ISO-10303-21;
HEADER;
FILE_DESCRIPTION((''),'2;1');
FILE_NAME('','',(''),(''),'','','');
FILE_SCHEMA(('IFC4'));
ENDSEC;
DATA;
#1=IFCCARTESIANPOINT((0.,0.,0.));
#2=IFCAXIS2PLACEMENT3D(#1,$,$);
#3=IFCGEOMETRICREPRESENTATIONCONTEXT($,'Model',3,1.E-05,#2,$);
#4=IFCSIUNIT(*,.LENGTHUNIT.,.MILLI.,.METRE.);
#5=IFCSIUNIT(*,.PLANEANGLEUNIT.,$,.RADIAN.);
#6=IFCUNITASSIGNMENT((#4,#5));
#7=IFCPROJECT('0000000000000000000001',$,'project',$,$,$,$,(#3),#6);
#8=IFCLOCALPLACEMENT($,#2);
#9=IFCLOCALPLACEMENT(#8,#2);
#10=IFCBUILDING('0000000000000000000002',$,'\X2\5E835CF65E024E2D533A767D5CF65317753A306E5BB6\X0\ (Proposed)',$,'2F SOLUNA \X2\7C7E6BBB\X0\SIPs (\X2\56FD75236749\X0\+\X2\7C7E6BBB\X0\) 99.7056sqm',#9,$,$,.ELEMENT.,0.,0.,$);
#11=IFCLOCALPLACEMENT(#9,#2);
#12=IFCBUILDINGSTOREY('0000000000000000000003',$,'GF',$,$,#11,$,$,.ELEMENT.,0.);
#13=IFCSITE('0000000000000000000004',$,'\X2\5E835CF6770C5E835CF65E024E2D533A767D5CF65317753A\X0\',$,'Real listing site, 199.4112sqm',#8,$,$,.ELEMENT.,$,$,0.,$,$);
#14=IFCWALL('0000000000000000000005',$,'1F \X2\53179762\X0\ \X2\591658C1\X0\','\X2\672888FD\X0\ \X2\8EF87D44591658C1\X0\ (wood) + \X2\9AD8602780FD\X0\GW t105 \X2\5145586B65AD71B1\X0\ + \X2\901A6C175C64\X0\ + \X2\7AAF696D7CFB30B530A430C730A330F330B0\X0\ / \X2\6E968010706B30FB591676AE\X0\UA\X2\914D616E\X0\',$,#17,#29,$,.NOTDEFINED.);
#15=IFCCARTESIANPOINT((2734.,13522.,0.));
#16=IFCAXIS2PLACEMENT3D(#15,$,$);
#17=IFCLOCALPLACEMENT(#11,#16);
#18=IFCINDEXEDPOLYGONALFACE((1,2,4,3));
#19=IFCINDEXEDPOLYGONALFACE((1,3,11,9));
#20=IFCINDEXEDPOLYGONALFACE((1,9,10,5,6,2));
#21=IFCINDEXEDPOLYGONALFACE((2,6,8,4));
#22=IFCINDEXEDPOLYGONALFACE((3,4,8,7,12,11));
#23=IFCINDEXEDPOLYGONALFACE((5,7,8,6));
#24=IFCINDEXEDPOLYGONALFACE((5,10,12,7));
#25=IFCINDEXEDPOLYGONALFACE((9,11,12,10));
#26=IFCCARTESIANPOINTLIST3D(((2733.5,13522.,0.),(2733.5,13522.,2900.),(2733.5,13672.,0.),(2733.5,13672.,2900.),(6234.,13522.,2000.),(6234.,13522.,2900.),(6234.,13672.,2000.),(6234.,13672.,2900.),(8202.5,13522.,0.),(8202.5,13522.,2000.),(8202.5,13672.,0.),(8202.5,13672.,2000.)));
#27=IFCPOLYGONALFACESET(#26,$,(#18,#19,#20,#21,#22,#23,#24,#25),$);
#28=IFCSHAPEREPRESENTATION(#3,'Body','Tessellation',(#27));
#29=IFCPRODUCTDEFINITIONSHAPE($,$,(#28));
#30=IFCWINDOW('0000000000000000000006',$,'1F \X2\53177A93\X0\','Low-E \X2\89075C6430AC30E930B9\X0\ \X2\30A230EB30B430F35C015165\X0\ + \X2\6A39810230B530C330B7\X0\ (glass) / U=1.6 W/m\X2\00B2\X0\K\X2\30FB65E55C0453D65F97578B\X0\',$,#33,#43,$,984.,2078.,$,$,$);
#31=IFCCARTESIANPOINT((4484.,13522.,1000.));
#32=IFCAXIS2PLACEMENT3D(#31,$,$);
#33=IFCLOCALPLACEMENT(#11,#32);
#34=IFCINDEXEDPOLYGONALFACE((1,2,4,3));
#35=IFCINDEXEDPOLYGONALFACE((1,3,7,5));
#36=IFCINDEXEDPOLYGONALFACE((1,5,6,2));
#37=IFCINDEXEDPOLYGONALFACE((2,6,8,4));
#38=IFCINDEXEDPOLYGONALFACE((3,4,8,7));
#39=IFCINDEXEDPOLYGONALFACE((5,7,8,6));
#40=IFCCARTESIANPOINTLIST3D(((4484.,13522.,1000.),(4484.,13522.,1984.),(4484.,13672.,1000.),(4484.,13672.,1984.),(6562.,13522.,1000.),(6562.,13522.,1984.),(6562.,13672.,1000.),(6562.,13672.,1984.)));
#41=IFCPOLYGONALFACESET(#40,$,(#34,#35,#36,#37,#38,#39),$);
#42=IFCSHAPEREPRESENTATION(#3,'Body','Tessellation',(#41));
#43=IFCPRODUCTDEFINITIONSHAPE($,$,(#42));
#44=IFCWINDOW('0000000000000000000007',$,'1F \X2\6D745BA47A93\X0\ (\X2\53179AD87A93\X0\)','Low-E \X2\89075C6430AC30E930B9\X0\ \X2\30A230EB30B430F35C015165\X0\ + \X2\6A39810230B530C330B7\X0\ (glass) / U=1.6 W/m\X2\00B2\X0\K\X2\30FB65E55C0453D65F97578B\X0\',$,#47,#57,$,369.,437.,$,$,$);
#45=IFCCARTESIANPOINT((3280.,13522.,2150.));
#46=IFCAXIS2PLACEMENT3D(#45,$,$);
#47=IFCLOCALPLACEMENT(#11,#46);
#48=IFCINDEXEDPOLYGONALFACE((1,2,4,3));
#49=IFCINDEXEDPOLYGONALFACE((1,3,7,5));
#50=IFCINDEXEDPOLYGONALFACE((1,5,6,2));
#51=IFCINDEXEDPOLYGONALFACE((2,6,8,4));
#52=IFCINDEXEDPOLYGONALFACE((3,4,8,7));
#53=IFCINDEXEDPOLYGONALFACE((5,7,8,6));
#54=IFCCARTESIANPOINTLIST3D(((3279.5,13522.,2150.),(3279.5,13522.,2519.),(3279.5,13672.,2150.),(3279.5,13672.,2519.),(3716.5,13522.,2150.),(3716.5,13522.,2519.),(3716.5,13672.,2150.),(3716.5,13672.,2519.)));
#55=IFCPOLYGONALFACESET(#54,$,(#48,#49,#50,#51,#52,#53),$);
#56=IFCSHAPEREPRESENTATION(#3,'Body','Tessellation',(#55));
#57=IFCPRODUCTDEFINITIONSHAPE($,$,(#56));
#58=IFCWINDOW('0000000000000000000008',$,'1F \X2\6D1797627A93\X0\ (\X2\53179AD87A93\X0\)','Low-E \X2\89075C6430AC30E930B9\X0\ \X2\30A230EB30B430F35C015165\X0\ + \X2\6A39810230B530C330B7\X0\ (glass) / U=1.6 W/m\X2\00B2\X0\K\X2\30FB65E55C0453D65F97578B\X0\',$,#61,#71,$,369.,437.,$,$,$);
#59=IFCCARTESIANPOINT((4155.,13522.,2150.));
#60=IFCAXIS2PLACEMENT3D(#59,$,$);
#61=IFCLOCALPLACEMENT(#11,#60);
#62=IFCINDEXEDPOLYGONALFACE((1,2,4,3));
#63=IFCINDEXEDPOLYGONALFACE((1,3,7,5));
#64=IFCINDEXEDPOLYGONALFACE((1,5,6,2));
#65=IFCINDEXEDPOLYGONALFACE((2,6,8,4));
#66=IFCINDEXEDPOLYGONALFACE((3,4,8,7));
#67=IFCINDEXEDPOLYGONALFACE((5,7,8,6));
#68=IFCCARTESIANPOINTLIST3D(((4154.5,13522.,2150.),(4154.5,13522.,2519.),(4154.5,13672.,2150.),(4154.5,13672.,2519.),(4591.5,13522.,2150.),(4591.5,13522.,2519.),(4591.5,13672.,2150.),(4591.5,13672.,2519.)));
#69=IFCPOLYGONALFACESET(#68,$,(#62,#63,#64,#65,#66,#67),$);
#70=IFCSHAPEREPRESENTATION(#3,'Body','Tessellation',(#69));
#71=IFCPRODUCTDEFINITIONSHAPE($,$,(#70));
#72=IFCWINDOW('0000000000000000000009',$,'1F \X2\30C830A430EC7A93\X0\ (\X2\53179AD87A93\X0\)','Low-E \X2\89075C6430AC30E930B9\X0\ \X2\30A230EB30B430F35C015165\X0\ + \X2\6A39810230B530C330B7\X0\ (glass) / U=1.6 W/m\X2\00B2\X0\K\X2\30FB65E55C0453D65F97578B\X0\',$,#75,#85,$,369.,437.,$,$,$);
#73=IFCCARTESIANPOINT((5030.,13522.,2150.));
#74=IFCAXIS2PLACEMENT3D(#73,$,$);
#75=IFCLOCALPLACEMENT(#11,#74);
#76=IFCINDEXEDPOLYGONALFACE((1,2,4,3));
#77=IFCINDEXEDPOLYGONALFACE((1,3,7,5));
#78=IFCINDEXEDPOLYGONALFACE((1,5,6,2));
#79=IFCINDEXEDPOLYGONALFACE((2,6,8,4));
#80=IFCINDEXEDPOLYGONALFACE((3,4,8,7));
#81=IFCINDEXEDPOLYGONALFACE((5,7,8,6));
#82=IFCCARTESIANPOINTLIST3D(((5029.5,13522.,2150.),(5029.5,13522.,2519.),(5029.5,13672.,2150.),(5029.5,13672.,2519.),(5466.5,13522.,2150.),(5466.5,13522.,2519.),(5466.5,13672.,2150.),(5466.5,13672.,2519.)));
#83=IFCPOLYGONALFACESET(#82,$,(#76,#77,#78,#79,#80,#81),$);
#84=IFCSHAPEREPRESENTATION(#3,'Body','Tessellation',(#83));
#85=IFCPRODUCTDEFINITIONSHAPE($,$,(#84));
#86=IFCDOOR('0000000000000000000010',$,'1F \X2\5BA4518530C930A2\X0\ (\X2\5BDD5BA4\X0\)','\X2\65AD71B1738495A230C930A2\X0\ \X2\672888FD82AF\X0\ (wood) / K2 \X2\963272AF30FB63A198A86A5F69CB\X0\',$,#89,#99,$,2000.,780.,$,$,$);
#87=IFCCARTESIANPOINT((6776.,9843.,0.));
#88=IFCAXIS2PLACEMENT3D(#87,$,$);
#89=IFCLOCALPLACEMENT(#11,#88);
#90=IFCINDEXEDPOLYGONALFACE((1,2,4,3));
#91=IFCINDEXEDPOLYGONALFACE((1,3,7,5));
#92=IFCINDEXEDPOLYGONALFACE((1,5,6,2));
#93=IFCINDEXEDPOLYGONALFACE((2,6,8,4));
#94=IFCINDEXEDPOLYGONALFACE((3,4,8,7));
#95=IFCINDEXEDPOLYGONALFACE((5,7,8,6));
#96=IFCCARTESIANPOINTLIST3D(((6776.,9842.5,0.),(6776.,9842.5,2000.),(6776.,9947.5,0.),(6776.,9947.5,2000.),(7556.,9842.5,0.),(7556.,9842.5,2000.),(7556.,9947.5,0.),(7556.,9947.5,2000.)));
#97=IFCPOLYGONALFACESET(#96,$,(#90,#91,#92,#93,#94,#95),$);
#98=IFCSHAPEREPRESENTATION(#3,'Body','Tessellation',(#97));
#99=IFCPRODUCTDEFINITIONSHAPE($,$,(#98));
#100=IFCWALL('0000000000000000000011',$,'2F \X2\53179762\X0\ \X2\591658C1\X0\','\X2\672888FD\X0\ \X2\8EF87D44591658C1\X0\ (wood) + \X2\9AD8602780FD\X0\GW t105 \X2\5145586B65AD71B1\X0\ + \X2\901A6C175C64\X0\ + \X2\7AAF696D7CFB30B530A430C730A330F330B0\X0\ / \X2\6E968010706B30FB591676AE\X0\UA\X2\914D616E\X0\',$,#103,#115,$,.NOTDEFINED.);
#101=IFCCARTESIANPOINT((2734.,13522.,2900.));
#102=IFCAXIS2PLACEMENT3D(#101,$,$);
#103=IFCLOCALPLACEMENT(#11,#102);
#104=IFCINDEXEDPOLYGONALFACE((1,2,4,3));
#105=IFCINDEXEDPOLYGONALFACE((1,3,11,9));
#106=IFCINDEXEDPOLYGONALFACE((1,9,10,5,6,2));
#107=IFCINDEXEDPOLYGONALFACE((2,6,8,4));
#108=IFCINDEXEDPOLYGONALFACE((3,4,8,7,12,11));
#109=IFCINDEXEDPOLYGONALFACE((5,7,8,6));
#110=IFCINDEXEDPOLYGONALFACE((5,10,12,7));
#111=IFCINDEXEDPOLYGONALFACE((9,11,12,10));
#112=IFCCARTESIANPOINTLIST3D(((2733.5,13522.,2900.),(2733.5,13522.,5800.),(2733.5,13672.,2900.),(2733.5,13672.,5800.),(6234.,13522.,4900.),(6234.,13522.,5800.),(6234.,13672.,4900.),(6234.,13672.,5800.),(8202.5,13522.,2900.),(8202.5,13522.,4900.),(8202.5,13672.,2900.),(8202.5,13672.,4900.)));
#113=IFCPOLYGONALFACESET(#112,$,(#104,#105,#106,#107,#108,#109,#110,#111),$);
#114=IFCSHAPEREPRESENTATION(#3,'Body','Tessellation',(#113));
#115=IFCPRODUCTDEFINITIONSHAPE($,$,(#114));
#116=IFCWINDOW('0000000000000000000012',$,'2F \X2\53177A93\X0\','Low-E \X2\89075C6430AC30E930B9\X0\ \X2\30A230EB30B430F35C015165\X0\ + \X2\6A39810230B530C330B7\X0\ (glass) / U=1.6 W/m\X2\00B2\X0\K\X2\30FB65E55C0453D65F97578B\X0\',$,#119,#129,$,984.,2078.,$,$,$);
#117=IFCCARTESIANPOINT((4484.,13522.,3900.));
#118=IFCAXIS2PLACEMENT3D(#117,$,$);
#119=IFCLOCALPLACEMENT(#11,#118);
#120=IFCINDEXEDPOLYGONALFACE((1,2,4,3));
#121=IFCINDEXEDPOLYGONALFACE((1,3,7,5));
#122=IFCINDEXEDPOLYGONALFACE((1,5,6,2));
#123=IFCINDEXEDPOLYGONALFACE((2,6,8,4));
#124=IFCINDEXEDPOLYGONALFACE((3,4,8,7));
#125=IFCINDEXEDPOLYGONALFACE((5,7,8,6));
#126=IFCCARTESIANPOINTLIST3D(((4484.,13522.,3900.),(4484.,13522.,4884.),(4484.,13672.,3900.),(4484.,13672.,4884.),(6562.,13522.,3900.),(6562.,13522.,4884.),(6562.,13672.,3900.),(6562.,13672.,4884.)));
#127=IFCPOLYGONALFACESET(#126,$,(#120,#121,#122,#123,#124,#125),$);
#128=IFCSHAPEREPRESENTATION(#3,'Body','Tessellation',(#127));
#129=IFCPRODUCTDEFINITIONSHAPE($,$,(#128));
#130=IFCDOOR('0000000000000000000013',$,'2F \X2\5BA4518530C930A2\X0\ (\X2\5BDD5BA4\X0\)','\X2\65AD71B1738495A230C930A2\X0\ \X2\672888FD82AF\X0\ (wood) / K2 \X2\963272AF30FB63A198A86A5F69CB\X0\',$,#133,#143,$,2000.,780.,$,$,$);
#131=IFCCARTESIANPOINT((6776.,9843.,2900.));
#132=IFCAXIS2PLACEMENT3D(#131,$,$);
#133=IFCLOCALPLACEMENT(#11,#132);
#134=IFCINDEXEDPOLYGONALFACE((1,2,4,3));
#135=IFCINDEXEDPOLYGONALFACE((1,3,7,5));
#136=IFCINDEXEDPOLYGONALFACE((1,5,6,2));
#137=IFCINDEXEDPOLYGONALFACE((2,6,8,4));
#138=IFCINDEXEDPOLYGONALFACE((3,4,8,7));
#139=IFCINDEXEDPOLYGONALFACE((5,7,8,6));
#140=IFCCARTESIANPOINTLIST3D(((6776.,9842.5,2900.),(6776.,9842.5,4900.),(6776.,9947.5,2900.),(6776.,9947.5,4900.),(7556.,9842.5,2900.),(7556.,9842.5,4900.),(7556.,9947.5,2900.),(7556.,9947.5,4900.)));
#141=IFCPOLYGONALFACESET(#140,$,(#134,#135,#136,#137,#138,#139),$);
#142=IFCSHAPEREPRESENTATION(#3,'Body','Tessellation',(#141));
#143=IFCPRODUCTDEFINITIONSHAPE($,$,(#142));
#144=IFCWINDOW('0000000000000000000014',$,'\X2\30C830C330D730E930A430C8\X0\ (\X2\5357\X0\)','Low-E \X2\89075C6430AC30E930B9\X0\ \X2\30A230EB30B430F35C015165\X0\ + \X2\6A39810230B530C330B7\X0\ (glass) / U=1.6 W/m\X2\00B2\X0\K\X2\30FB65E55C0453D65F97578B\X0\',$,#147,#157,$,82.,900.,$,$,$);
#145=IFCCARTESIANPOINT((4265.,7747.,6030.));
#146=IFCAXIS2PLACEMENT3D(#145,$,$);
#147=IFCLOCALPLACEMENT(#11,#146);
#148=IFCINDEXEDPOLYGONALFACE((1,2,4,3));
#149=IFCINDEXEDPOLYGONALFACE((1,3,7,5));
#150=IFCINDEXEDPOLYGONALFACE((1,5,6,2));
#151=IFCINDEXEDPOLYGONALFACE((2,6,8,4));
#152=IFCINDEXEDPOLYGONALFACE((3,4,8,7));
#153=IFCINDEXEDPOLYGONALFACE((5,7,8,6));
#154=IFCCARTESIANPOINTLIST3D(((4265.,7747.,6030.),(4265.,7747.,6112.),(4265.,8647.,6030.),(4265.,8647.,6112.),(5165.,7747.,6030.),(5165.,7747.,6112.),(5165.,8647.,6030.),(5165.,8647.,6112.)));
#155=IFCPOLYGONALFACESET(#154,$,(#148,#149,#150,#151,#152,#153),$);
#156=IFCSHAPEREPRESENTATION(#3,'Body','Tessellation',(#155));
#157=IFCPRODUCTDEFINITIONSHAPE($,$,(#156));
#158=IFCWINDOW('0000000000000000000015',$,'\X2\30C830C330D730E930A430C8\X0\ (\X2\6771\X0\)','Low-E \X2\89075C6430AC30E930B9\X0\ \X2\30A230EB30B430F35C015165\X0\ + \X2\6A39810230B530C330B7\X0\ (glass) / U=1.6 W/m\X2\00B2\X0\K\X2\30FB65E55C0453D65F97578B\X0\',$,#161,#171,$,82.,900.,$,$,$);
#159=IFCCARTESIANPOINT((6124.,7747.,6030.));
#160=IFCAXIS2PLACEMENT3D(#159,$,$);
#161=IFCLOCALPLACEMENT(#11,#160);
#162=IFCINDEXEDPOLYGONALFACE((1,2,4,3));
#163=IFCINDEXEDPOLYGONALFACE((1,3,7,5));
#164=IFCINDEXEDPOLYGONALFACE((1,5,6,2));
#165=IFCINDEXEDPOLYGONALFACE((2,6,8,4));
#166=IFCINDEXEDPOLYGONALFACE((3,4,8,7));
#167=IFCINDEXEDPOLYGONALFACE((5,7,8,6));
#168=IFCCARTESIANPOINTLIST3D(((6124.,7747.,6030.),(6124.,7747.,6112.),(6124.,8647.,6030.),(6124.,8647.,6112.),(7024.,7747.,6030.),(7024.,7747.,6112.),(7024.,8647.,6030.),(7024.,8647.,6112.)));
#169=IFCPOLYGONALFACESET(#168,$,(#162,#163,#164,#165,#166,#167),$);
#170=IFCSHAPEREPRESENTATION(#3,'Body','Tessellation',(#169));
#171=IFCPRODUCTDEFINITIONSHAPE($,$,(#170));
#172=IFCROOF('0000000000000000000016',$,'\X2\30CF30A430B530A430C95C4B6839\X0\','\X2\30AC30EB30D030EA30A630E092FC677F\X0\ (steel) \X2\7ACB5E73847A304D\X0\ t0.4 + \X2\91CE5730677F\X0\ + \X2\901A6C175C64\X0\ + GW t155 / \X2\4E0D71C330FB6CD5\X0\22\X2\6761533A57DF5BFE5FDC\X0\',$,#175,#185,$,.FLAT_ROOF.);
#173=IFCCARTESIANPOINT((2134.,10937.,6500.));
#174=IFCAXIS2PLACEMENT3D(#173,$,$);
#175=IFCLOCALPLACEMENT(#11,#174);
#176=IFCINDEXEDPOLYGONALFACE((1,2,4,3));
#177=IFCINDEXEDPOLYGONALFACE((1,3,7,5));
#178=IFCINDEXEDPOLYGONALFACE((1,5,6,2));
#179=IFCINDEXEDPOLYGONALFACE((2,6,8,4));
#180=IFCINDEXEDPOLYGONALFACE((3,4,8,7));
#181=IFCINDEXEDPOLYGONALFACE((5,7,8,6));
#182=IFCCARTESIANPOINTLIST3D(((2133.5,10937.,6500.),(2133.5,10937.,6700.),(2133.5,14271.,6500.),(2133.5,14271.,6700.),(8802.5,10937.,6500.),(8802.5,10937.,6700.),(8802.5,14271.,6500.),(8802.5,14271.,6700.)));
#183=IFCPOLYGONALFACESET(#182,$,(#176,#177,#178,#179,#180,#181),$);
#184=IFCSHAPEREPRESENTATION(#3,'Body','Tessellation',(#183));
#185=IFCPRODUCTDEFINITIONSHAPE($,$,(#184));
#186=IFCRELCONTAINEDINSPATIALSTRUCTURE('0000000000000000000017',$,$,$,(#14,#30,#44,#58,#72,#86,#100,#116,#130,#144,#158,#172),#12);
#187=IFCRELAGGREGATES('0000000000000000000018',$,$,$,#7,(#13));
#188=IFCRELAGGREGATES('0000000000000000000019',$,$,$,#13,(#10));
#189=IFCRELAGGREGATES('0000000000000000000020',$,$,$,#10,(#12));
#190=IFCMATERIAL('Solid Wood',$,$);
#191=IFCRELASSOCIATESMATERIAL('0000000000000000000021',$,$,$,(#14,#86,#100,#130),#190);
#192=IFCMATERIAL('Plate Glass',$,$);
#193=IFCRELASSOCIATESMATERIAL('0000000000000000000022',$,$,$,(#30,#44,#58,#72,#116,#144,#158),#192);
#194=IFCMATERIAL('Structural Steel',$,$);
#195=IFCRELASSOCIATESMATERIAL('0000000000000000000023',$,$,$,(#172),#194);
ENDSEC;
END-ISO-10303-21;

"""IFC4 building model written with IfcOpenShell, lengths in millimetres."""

from ifc_helpers import new_model, si_unit, frame, frame_2d, origin, place, context, project, spatial, rectangle, extrude, material, element, fill, save


model = new_model("IFC4")

# Units and contexts
model_context = context("Model", 3, precision=1e-05, world=origin())
ifc_project = project(units=[si_unit("LENGTHUNIT", "METRE", prefix="MILLI"), si_unit("PLANEANGLEUNIT", "RADIAN")], contexts=[model_context])

# Site, building, storey
site_placement = place(None, origin())
site = spatial("IfcSite", under=ifc_project, at=site_placement, Name="広島県広島市中区白島北町", ObjectType="Real listing site, 199.4112sqm", CompositionType="ELEMENT", RefElevation=0.0)
building_placement = place(site_placement, origin())
building = spatial("IfcBuilding", under=site, at=building_placement, Name="広島市中区白島北町の家 (Proposed)", ObjectType="2F SOLUNA 籾殻SIPs (国産杉+籾殻) 99.7056sqm", CompositionType="ELEMENT", ElevationOfRefHeight=0.0, ElevationOfTerrain=0.0)
storey_placement = place(building_placement, origin())
storey = spatial("IfcBuildingStorey", under=building, at=storey_placement, Name="GF", CompositionType="ELEMENT", Elevation=0.0)

# Wall, openings, windows
ifc_material_1 = material(Name="Solid Wood")
wall_1_placement = place(storey_placement, frame((2734.0, 13522.0, 0.0)))
wall_1 = element("IfcWall", 1, at=wall_1_placement, inside=storey, material=ifc_material_1, Name="1F 北面 外壁", Description="木製 軸組外壁 (wood) + 高性能GW t105 充填断熱 + 通気層 + 窯業系サイディング / 準耐火・外皮UA配慮", PredefinedType="NOTDEFINED", context=model_context, shape_type="SweptSolid", body=[
    extrude(rectangle(XDim=5469.0, YDim=150.0, at=frame_2d((2734.0, 75.0))), frame((2734.0, 13522.0, 0.0)), (0.0, 0.0, 1.0), 2900.0),
])
opening_1_placement = place(storey_placement, frame((4484.0, 13522.0, 1000.0)))
opening_1 = element("IfcOpeningElement", 2, at=opening_1_placement, cuts=wall_1, PredefinedType="NOTDEFINED", context=model_context, shape_type="SweptSolid", body=[
    extrude(rectangle(XDim=2078.0, YDim=150.0, at=frame_2d((1039.0, 75.0))), frame((4484.0, 13522.0, 1000.0)), (0.0, 0.0, 1.0), 984.0),
])
opening_2_placement = place(storey_placement, frame((3280.0, 13522.0, 2150.0)))
opening_2 = element("IfcOpeningElement", 3, at=opening_2_placement, cuts=wall_1, PredefinedType="NOTDEFINED", context=model_context, shape_type="SweptSolid", body=[
    extrude(rectangle(XDim=437.0, YDim=150.0, at=frame_2d((218.0, 75.0))), frame((3280.0, 13522.0, 2150.0)), (0.0, 0.0, 1.0), 369.0),
])
opening_3_placement = place(storey_placement, frame((4155.0, 13522.0, 2150.0)))
opening_3 = element("IfcOpeningElement", 4, at=opening_3_placement, cuts=wall_1, PredefinedType="NOTDEFINED", context=model_context, shape_type="SweptSolid", body=[
    extrude(rectangle(XDim=437.0, YDim=150.0, at=frame_2d((218.0, 75.0))), frame((4155.0, 13522.0, 2150.0)), (0.0, 0.0, 1.0), 369.0),
])
opening_4_placement = place(storey_placement, frame((5030.0, 13522.0, 2150.0)))
opening_4 = element("IfcOpeningElement", 5, at=opening_4_placement, cuts=wall_1, PredefinedType="NOTDEFINED", context=model_context, shape_type="SweptSolid", body=[
    extrude(rectangle(XDim=437.0, YDim=150.0, at=frame_2d((218.0, 75.0))), frame((5030.0, 13522.0, 2150.0)), (0.0, 0.0, 1.0), 369.0),
])
ifc_material_2 = material(Name="Plate Glass")
window_1_placement = place(storey_placement, frame((4484.0, 13522.0, 1000.0)))
window_1 = element("IfcWindow", 6, at=window_1_placement, inside=storey, material=ifc_material_2, Name="1F 北窓", Description="Low-E 複層ガラス アルゴン封入 + 樹脂サッシ (glass) / U=1.6 W/m²K・日射取得型", OverallHeight=984.0, OverallWidth=2078.0, context=model_context, shape_type="SweptSolid", body=[
    extrude(rectangle(XDim=2078.0, YDim=150.0, at=frame_2d((1039.0, 75.0))), frame((4484.0, 13522.0, 1000.0)), (0.0, 0.0, 1.0), 984.0),
])
fill(opening_1, window_1)
window_2_placement = place(storey_placement, frame((3280.0, 13522.0, 2150.0)))
window_2 = element("IfcWindow", 7, at=window_2_placement, inside=storey, material=ifc_material_2, Name="1F 浴室窓 (北高窓)", Description="Low-E 複層ガラス アルゴン封入 + 樹脂サッシ (glass) / U=1.6 W/m²K・日射取得型", OverallHeight=369.0, OverallWidth=437.0, context=model_context, shape_type="SweptSolid", body=[
    extrude(rectangle(XDim=437.0, YDim=150.0, at=frame_2d((218.0, 75.0))), frame((3280.0, 13522.0, 2150.0)), (0.0, 0.0, 1.0), 369.0),
])
fill(opening_2, window_2)
window_3_placement = place(storey_placement, frame((4155.0, 13522.0, 2150.0)))
window_3 = element("IfcWindow", 8, at=window_3_placement, inside=storey, material=ifc_material_2, Name="1F 洗面窓 (北高窓)", Description="Low-E 複層ガラス アルゴン封入 + 樹脂サッシ (glass) / U=1.6 W/m²K・日射取得型", OverallHeight=369.0, OverallWidth=437.0, context=model_context, shape_type="SweptSolid", body=[
    extrude(rectangle(XDim=437.0, YDim=150.0, at=frame_2d((218.0, 75.0))), frame((4155.0, 13522.0, 2150.0)), (0.0, 0.0, 1.0), 369.0),
])
fill(opening_3, window_3)
window_4_placement = place(storey_placement, frame((5030.0, 13522.0, 2150.0)))
window_4 = element("IfcWindow", 9, at=window_4_placement, inside=storey, material=ifc_material_2, Name="1F トイレ窓 (北高窓)", Description="Low-E 複層ガラス アルゴン封入 + 樹脂サッシ (glass) / U=1.6 W/m²K・日射取得型", OverallHeight=369.0, OverallWidth=437.0, context=model_context, shape_type="SweptSolid", body=[
    extrude(rectangle(XDim=437.0, YDim=150.0, at=frame_2d((218.0, 75.0))), frame((5030.0, 13522.0, 2150.0)), (0.0, 0.0, 1.0), 369.0),
])
fill(opening_4, window_4)

# Door
door_1_placement = place(storey_placement, frame((6776.0, 9843.0, 0.0)))
element("IfcDoor", 10, at=door_1_placement, inside=storey, material=ifc_material_1, Name="1F 室内ドア (寝室)", Description="断熱玄関ドア 木製芯 (wood) / K2 防犯・採風機構", OverallHeight=2000.0, OverallWidth=780.0, context=model_context, shape_type="SweptSolid", body=[
    extrude(rectangle(XDim=780.0, YDim=105.0, at=frame_2d((390.0, 52.0))), frame((6776.0, 9843.0, 0.0)), (0.0, 0.0, 1.0), 2000.0),
])

# Wall, opening, window
wall_2_placement = place(storey_placement, frame((2734.0, 13522.0, 2900.0)))
wall_2 = element("IfcWall", 11, at=wall_2_placement, inside=storey, material=ifc_material_1, Name="2F 北面 外壁", Description="木製 軸組外壁 (wood) + 高性能GW t105 充填断熱 + 通気層 + 窯業系サイディング / 準耐火・外皮UA配慮", PredefinedType="NOTDEFINED", context=model_context, shape_type="SweptSolid", body=[
    extrude(rectangle(XDim=5469.0, YDim=150.0, at=frame_2d((2734.0, 75.0))), frame((2734.0, 13522.0, 2900.0)), (0.0, 0.0, 1.0), 2900.0),
])
opening_5_placement = place(storey_placement, frame((4484.0, 13522.0, 3900.0)))
opening_5 = element("IfcOpeningElement", 12, at=opening_5_placement, cuts=wall_2, PredefinedType="NOTDEFINED", context=model_context, shape_type="SweptSolid", body=[
    extrude(rectangle(XDim=2078.0, YDim=150.0, at=frame_2d((1039.0, 75.0))), frame((4484.0, 13522.0, 3900.0)), (0.0, 0.0, 1.0), 984.0),
])
window_5_placement = place(storey_placement, frame((4484.0, 13522.0, 3900.0)))
window_5 = element("IfcWindow", 13, at=window_5_placement, inside=storey, material=ifc_material_2, Name="2F 北窓", Description="Low-E 複層ガラス アルゴン封入 + 樹脂サッシ (glass) / U=1.6 W/m²K・日射取得型", OverallHeight=984.0, OverallWidth=2078.0, context=model_context, shape_type="SweptSolid", body=[
    extrude(rectangle(XDim=2078.0, YDim=150.0, at=frame_2d((1039.0, 75.0))), frame((4484.0, 13522.0, 3900.0)), (0.0, 0.0, 1.0), 984.0),
])
fill(opening_5, window_5)

# Door
door_2_placement = place(storey_placement, frame((6776.0, 9843.0, 2900.0)))
element("IfcDoor", 14, at=door_2_placement, inside=storey, material=ifc_material_1, Name="2F 室内ドア (寝室)", Description="断熱玄関ドア 木製芯 (wood) / K2 防犯・採風機構", OverallHeight=2000.0, OverallWidth=780.0, context=model_context, shape_type="SweptSolid", body=[
    extrude(rectangle(XDim=780.0, YDim=105.0, at=frame_2d((390.0, 52.0))), frame((6776.0, 9843.0, 2900.0)), (0.0, 0.0, 1.0), 2000.0),
])

# Windows
window_6_placement = place(storey_placement, frame((4265.0, 7747.0, 6030.0)))
element("IfcWindow", 15, at=window_6_placement, inside=storey, material=ifc_material_2, Name="トップライト (南)", Description="Low-E 複層ガラス アルゴン封入 + 樹脂サッシ (glass) / U=1.6 W/m²K・日射取得型", OverallHeight=82.0, OverallWidth=900.0, context=model_context, shape_type="SweptSolid", body=[
    extrude(rectangle(XDim=900.0, YDim=900.0, at=frame_2d((450.0, 450.0))), frame((4265.0, 7747.0, 6030.0)), (0.0, 0.0, 1.0), 82.0),
])
window_7_placement = place(storey_placement, frame((6124.0, 7747.0, 6030.0)))
element("IfcWindow", 16, at=window_7_placement, inside=storey, material=ifc_material_2, Name="トップライト (東)", Description="Low-E 複層ガラス アルゴン封入 + 樹脂サッシ (glass) / U=1.6 W/m²K・日射取得型", OverallHeight=82.0, OverallWidth=900.0, context=model_context, shape_type="SweptSolid", body=[
    extrude(rectangle(XDim=900.0, YDim=900.0, at=frame_2d((450.0, 450.0))), frame((6124.0, 7747.0, 6030.0)), (0.0, 0.0, 1.0), 82.0),
])

# Roof
ifc_material_3 = material(Name="Structural Steel")
roof_placement = place(storey_placement, frame((2134.0, 10937.0, 6500.0)))
element("IfcRoof", 17, at=roof_placement, inside=storey, material=ifc_material_3, Name="ハイサイド屋根", Description="ガルバリウム鋼板 (steel) 立平葺き t0.4 + 野地板 + 通気層 + GW t155 / 不燃・法22条区域対応", PredefinedType="FLAT_ROOF", context=model_context, shape_type="SweptSolid", body=[
    extrude(rectangle(XDim=6669.0, YDim=3334.0, at=frame_2d((3334.0, 1667.0))), frame((2134.0, 10937.0, 6500.0)), (0.0, 0.0, 1.0), 200.0),
])

save(model, "model.ifc")
